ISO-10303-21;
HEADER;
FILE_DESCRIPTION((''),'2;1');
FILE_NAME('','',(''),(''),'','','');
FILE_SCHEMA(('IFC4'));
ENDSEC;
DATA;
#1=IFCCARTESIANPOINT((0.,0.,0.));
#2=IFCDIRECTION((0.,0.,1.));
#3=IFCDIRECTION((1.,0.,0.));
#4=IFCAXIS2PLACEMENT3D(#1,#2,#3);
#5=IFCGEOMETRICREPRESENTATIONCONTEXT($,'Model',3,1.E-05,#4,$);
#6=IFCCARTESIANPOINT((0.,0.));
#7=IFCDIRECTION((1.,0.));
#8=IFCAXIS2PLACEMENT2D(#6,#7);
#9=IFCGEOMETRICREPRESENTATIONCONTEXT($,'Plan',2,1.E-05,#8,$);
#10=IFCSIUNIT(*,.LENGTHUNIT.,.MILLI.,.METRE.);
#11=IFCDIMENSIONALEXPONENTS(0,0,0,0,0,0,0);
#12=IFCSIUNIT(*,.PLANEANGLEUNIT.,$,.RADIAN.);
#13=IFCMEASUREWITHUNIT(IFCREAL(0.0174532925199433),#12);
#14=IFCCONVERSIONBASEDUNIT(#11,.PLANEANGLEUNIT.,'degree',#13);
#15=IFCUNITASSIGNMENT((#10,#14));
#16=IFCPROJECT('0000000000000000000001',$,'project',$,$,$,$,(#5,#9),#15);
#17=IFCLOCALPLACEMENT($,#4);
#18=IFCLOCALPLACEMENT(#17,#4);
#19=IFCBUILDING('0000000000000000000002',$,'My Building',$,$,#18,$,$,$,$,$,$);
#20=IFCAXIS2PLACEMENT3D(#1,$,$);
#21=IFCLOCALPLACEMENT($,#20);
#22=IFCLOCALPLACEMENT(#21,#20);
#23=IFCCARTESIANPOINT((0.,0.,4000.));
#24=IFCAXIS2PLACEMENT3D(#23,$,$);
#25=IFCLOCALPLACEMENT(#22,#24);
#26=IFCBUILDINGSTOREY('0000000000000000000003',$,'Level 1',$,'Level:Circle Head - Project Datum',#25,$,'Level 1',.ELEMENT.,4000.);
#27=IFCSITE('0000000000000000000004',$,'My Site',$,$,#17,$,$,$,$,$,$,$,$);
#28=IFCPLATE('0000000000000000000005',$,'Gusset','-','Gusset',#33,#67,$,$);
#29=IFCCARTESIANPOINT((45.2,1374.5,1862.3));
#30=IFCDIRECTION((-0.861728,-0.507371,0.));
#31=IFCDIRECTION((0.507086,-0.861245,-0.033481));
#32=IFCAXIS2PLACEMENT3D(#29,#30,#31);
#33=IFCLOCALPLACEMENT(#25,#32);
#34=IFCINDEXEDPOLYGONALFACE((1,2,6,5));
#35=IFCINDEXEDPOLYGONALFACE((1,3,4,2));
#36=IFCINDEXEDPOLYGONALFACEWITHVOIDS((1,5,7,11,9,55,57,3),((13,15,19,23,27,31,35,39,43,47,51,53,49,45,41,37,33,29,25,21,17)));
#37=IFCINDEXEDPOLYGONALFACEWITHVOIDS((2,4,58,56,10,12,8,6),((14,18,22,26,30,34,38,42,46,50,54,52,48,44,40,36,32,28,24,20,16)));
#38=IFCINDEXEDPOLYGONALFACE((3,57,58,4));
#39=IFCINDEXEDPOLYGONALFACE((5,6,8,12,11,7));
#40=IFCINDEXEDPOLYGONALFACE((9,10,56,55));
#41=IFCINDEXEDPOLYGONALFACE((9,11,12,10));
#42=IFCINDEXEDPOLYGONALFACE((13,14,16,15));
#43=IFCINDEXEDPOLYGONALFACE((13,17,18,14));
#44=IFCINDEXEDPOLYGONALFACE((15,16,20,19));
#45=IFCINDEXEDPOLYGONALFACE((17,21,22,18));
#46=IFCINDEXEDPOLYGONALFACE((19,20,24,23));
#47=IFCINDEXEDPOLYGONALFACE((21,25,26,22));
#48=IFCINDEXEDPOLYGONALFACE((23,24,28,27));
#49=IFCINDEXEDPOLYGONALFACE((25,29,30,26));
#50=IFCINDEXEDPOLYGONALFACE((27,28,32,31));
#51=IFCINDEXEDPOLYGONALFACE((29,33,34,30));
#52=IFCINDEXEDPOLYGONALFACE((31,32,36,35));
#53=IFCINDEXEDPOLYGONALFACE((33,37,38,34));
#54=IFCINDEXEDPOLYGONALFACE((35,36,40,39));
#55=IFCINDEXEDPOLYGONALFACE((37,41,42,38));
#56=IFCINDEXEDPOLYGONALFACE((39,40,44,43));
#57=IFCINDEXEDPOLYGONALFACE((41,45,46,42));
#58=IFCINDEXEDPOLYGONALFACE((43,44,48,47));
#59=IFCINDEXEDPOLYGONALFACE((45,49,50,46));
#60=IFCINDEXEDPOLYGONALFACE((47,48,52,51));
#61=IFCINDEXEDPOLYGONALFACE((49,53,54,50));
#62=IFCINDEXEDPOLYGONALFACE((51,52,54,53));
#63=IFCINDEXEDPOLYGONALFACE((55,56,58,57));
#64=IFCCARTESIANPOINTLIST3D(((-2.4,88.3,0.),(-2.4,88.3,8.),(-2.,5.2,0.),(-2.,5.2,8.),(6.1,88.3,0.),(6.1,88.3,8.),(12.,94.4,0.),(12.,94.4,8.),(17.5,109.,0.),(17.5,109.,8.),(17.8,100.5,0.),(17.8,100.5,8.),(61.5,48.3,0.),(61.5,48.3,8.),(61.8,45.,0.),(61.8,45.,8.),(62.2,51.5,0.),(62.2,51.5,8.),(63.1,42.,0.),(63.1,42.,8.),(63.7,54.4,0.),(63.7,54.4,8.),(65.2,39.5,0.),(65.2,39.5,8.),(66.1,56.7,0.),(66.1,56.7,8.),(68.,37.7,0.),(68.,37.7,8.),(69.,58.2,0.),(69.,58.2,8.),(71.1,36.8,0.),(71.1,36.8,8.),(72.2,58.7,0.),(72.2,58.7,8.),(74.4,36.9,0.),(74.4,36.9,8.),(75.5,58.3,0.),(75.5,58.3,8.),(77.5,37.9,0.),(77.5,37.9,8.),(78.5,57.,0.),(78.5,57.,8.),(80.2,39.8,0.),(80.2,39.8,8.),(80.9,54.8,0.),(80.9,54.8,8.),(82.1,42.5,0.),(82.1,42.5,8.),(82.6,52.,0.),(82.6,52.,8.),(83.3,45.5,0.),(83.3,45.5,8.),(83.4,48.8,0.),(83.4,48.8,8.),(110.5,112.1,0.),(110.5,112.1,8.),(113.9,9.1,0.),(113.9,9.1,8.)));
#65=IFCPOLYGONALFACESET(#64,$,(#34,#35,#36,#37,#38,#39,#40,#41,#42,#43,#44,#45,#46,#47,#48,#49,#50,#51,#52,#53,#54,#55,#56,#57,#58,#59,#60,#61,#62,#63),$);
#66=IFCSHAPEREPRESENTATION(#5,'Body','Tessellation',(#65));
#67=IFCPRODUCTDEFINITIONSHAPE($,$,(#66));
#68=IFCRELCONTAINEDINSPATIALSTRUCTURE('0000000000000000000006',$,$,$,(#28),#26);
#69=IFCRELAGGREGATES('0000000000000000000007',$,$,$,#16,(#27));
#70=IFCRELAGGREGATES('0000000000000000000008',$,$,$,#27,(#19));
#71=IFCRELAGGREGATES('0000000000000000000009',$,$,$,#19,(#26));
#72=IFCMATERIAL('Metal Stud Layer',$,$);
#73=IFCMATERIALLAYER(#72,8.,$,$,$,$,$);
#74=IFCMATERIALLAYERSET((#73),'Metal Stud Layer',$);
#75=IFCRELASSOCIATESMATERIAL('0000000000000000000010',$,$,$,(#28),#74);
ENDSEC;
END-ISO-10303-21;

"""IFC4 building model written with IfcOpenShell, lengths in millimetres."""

from ifc_helpers import new_model, entity, si_unit, converted_unit, point, frame, frame_2d, origin, origin_with_axes, origin_2d_with_axis, place, context, project, spatial, polyline, circle_curve, line_curve, trimmed, segment, composite_curve, circle, outline, extrude, material, layer, layer_set, element, save


model = new_model("IFC4")

# Units and contexts
model_context = context("Model", 3, precision=1e-05, world=origin_with_axes())
plan_context = context("Plan", 2, precision=1e-05, world=origin_2d_with_axis())
ifc_project = project(units=[si_unit("LENGTHUNIT", "METRE", prefix="MILLI"), converted_unit("PLANEANGLEUNIT", "degree", entity("IfcReal", 0.0174532925199433), si_unit("PLANEANGLEUNIT", "RADIAN"), dimensions=[0, 0, 0, 0, 0, 0, 0])], contexts=[model_context, plan_context])

# Site, building, storey
site_placement = place(None, origin_with_axes())
site = spatial("IfcSite", under=ifc_project, at=site_placement, Name="My Site")
building_placement = place(site_placement, origin_with_axes())
building = spatial("IfcBuilding", under=site, at=building_placement, Name="My Building")
placement_1 = place(None, origin())
placement_2 = place(placement_1, origin())
storey_placement = place(placement_2, frame((0.0, 0.0, 4000.0)))
storey = spatial("IfcBuildingStorey", under=building, at=storey_placement, Name="Level 1", ObjectType="Level:Circle Head - Project Datum", LongName="Level 1", CompositionType="ELEMENT", Elevation=4000.0)

# Plate, openings
ifc_material_1 = material(Name="Metal Stud Layer")
ifc_layer_1 = layer(ifc_material_1, 8.0)
ifc_layer_set_1 = layer_set([ifc_layer_1], Name="Metal Stud Layer")
plate_1_placement = place(storey_placement, frame((45.2, 1374.5, 1862.3), z_axis=(-0.861728, -0.507371, 0.0), x_axis=(0.507086, -0.861245, -0.033481)))
plate_1 = element("IfcPlate", 1, at=plate_1_placement, inside=storey, material=ifc_layer_set_1, Name="Gusset", Description="-", ObjectType="Gusset", context=model_context, shape_type="SweptSolid", body=[
    extrude(outline(polyline([(-2.0, 5.2), (113.9, 9.1), (110.5, 112.1), (17.5, 109.0), (17.8, 100.5), (6.1, 88.3), (-2.4, 88.3), (-2.0, 5.2)])), origin_with_axes(), (0.0, 0.0, 1.0), 8.0),
])
opening_1_placement = place(plate_1_placement, frame((72.5, 47.7, -0.5), z_axis=(0.0, 0.0, 1.0), x_axis=(0.8774, -0.47976, 0.0)))
element("IfcOpeningElement", 2, at=opening_1_placement, cuts=plate_1, ObjectType="Opening", context=model_context, shape_type="SweptSolid", body=[
    extrude(circle(Radius=11.0, at=origin_2d_with_axis()), origin(), (0.0, 0.0, 1.0), 9.0),
])
opening_2_placement = place(plate_1_placement, origin_with_axes())
element("IfcOpeningElement", 3, at=opening_2_placement, cuts=plate_1, ObjectType="Opening", context=model_context, shape_type="SweptSolid", body=[
    extrude(outline(composite_curve([segment(trimmed(line_curve((17.8, 100.5), (-0.693597, -0.720363), 8.455359), [point((17.8, 100.5))], [point((12.0, 94.4))], True, "CARTESIAN"), True, "CONTINUOUS"), segment(trimmed(circle_curve(frame_2d((-2.4, 108.3), x_axis=(1.0, 0.0)), 20.0), [point((12.0, 94.4))], [point((17.5, 109.0))], True, "CARTESIAN"), True, "CONTINUOUS"), segment(trimmed(line_curve((17.5, 109.0), (0.033481, -0.999439), 8.455359), [point((17.5, 109.0))], [point((17.8, 100.5))], True, "CARTESIAN"), True, "CONTINUOUS")], self_intersect=False)), origin(), (0.0, 0.0, 1.0), 8.0),
])
opening_3_placement = place(plate_1_placement, origin_with_axes())
element("IfcOpeningElement", 4, at=opening_3_placement, cuts=plate_1, ObjectType="Opening", context=model_context, shape_type="SweptSolid", body=[
    extrude(outline(composite_curve([segment(trimmed(line_curve((6.1, 88.3), (-0.99999, -0.004369), 8.455359), [point((6.1, 88.3))], [point((-2.4, 88.3))], True, "CARTESIAN"), True, "CONTINUOUS"), segment(trimmed(circle_curve(frame_2d((-2.4, 108.3), x_axis=(1.0, 0.0)), 20.0), [point((-2.4, 88.3))], [point((12.0, 94.4))], True, "CARTESIAN"), True, "CONTINUOUS"), segment(trimmed(line_curve((12.0, 94.4), (-0.693597, -0.720363), 8.455359), [point((12.0, 94.4))], [point((6.1, 88.3))], True, "CARTESIAN"), True, "CONTINUOUS")], self_intersect=False)), origin(), (0.0, 0.0, 1.0), 8.0),
])

save(model, "model.ifc")
